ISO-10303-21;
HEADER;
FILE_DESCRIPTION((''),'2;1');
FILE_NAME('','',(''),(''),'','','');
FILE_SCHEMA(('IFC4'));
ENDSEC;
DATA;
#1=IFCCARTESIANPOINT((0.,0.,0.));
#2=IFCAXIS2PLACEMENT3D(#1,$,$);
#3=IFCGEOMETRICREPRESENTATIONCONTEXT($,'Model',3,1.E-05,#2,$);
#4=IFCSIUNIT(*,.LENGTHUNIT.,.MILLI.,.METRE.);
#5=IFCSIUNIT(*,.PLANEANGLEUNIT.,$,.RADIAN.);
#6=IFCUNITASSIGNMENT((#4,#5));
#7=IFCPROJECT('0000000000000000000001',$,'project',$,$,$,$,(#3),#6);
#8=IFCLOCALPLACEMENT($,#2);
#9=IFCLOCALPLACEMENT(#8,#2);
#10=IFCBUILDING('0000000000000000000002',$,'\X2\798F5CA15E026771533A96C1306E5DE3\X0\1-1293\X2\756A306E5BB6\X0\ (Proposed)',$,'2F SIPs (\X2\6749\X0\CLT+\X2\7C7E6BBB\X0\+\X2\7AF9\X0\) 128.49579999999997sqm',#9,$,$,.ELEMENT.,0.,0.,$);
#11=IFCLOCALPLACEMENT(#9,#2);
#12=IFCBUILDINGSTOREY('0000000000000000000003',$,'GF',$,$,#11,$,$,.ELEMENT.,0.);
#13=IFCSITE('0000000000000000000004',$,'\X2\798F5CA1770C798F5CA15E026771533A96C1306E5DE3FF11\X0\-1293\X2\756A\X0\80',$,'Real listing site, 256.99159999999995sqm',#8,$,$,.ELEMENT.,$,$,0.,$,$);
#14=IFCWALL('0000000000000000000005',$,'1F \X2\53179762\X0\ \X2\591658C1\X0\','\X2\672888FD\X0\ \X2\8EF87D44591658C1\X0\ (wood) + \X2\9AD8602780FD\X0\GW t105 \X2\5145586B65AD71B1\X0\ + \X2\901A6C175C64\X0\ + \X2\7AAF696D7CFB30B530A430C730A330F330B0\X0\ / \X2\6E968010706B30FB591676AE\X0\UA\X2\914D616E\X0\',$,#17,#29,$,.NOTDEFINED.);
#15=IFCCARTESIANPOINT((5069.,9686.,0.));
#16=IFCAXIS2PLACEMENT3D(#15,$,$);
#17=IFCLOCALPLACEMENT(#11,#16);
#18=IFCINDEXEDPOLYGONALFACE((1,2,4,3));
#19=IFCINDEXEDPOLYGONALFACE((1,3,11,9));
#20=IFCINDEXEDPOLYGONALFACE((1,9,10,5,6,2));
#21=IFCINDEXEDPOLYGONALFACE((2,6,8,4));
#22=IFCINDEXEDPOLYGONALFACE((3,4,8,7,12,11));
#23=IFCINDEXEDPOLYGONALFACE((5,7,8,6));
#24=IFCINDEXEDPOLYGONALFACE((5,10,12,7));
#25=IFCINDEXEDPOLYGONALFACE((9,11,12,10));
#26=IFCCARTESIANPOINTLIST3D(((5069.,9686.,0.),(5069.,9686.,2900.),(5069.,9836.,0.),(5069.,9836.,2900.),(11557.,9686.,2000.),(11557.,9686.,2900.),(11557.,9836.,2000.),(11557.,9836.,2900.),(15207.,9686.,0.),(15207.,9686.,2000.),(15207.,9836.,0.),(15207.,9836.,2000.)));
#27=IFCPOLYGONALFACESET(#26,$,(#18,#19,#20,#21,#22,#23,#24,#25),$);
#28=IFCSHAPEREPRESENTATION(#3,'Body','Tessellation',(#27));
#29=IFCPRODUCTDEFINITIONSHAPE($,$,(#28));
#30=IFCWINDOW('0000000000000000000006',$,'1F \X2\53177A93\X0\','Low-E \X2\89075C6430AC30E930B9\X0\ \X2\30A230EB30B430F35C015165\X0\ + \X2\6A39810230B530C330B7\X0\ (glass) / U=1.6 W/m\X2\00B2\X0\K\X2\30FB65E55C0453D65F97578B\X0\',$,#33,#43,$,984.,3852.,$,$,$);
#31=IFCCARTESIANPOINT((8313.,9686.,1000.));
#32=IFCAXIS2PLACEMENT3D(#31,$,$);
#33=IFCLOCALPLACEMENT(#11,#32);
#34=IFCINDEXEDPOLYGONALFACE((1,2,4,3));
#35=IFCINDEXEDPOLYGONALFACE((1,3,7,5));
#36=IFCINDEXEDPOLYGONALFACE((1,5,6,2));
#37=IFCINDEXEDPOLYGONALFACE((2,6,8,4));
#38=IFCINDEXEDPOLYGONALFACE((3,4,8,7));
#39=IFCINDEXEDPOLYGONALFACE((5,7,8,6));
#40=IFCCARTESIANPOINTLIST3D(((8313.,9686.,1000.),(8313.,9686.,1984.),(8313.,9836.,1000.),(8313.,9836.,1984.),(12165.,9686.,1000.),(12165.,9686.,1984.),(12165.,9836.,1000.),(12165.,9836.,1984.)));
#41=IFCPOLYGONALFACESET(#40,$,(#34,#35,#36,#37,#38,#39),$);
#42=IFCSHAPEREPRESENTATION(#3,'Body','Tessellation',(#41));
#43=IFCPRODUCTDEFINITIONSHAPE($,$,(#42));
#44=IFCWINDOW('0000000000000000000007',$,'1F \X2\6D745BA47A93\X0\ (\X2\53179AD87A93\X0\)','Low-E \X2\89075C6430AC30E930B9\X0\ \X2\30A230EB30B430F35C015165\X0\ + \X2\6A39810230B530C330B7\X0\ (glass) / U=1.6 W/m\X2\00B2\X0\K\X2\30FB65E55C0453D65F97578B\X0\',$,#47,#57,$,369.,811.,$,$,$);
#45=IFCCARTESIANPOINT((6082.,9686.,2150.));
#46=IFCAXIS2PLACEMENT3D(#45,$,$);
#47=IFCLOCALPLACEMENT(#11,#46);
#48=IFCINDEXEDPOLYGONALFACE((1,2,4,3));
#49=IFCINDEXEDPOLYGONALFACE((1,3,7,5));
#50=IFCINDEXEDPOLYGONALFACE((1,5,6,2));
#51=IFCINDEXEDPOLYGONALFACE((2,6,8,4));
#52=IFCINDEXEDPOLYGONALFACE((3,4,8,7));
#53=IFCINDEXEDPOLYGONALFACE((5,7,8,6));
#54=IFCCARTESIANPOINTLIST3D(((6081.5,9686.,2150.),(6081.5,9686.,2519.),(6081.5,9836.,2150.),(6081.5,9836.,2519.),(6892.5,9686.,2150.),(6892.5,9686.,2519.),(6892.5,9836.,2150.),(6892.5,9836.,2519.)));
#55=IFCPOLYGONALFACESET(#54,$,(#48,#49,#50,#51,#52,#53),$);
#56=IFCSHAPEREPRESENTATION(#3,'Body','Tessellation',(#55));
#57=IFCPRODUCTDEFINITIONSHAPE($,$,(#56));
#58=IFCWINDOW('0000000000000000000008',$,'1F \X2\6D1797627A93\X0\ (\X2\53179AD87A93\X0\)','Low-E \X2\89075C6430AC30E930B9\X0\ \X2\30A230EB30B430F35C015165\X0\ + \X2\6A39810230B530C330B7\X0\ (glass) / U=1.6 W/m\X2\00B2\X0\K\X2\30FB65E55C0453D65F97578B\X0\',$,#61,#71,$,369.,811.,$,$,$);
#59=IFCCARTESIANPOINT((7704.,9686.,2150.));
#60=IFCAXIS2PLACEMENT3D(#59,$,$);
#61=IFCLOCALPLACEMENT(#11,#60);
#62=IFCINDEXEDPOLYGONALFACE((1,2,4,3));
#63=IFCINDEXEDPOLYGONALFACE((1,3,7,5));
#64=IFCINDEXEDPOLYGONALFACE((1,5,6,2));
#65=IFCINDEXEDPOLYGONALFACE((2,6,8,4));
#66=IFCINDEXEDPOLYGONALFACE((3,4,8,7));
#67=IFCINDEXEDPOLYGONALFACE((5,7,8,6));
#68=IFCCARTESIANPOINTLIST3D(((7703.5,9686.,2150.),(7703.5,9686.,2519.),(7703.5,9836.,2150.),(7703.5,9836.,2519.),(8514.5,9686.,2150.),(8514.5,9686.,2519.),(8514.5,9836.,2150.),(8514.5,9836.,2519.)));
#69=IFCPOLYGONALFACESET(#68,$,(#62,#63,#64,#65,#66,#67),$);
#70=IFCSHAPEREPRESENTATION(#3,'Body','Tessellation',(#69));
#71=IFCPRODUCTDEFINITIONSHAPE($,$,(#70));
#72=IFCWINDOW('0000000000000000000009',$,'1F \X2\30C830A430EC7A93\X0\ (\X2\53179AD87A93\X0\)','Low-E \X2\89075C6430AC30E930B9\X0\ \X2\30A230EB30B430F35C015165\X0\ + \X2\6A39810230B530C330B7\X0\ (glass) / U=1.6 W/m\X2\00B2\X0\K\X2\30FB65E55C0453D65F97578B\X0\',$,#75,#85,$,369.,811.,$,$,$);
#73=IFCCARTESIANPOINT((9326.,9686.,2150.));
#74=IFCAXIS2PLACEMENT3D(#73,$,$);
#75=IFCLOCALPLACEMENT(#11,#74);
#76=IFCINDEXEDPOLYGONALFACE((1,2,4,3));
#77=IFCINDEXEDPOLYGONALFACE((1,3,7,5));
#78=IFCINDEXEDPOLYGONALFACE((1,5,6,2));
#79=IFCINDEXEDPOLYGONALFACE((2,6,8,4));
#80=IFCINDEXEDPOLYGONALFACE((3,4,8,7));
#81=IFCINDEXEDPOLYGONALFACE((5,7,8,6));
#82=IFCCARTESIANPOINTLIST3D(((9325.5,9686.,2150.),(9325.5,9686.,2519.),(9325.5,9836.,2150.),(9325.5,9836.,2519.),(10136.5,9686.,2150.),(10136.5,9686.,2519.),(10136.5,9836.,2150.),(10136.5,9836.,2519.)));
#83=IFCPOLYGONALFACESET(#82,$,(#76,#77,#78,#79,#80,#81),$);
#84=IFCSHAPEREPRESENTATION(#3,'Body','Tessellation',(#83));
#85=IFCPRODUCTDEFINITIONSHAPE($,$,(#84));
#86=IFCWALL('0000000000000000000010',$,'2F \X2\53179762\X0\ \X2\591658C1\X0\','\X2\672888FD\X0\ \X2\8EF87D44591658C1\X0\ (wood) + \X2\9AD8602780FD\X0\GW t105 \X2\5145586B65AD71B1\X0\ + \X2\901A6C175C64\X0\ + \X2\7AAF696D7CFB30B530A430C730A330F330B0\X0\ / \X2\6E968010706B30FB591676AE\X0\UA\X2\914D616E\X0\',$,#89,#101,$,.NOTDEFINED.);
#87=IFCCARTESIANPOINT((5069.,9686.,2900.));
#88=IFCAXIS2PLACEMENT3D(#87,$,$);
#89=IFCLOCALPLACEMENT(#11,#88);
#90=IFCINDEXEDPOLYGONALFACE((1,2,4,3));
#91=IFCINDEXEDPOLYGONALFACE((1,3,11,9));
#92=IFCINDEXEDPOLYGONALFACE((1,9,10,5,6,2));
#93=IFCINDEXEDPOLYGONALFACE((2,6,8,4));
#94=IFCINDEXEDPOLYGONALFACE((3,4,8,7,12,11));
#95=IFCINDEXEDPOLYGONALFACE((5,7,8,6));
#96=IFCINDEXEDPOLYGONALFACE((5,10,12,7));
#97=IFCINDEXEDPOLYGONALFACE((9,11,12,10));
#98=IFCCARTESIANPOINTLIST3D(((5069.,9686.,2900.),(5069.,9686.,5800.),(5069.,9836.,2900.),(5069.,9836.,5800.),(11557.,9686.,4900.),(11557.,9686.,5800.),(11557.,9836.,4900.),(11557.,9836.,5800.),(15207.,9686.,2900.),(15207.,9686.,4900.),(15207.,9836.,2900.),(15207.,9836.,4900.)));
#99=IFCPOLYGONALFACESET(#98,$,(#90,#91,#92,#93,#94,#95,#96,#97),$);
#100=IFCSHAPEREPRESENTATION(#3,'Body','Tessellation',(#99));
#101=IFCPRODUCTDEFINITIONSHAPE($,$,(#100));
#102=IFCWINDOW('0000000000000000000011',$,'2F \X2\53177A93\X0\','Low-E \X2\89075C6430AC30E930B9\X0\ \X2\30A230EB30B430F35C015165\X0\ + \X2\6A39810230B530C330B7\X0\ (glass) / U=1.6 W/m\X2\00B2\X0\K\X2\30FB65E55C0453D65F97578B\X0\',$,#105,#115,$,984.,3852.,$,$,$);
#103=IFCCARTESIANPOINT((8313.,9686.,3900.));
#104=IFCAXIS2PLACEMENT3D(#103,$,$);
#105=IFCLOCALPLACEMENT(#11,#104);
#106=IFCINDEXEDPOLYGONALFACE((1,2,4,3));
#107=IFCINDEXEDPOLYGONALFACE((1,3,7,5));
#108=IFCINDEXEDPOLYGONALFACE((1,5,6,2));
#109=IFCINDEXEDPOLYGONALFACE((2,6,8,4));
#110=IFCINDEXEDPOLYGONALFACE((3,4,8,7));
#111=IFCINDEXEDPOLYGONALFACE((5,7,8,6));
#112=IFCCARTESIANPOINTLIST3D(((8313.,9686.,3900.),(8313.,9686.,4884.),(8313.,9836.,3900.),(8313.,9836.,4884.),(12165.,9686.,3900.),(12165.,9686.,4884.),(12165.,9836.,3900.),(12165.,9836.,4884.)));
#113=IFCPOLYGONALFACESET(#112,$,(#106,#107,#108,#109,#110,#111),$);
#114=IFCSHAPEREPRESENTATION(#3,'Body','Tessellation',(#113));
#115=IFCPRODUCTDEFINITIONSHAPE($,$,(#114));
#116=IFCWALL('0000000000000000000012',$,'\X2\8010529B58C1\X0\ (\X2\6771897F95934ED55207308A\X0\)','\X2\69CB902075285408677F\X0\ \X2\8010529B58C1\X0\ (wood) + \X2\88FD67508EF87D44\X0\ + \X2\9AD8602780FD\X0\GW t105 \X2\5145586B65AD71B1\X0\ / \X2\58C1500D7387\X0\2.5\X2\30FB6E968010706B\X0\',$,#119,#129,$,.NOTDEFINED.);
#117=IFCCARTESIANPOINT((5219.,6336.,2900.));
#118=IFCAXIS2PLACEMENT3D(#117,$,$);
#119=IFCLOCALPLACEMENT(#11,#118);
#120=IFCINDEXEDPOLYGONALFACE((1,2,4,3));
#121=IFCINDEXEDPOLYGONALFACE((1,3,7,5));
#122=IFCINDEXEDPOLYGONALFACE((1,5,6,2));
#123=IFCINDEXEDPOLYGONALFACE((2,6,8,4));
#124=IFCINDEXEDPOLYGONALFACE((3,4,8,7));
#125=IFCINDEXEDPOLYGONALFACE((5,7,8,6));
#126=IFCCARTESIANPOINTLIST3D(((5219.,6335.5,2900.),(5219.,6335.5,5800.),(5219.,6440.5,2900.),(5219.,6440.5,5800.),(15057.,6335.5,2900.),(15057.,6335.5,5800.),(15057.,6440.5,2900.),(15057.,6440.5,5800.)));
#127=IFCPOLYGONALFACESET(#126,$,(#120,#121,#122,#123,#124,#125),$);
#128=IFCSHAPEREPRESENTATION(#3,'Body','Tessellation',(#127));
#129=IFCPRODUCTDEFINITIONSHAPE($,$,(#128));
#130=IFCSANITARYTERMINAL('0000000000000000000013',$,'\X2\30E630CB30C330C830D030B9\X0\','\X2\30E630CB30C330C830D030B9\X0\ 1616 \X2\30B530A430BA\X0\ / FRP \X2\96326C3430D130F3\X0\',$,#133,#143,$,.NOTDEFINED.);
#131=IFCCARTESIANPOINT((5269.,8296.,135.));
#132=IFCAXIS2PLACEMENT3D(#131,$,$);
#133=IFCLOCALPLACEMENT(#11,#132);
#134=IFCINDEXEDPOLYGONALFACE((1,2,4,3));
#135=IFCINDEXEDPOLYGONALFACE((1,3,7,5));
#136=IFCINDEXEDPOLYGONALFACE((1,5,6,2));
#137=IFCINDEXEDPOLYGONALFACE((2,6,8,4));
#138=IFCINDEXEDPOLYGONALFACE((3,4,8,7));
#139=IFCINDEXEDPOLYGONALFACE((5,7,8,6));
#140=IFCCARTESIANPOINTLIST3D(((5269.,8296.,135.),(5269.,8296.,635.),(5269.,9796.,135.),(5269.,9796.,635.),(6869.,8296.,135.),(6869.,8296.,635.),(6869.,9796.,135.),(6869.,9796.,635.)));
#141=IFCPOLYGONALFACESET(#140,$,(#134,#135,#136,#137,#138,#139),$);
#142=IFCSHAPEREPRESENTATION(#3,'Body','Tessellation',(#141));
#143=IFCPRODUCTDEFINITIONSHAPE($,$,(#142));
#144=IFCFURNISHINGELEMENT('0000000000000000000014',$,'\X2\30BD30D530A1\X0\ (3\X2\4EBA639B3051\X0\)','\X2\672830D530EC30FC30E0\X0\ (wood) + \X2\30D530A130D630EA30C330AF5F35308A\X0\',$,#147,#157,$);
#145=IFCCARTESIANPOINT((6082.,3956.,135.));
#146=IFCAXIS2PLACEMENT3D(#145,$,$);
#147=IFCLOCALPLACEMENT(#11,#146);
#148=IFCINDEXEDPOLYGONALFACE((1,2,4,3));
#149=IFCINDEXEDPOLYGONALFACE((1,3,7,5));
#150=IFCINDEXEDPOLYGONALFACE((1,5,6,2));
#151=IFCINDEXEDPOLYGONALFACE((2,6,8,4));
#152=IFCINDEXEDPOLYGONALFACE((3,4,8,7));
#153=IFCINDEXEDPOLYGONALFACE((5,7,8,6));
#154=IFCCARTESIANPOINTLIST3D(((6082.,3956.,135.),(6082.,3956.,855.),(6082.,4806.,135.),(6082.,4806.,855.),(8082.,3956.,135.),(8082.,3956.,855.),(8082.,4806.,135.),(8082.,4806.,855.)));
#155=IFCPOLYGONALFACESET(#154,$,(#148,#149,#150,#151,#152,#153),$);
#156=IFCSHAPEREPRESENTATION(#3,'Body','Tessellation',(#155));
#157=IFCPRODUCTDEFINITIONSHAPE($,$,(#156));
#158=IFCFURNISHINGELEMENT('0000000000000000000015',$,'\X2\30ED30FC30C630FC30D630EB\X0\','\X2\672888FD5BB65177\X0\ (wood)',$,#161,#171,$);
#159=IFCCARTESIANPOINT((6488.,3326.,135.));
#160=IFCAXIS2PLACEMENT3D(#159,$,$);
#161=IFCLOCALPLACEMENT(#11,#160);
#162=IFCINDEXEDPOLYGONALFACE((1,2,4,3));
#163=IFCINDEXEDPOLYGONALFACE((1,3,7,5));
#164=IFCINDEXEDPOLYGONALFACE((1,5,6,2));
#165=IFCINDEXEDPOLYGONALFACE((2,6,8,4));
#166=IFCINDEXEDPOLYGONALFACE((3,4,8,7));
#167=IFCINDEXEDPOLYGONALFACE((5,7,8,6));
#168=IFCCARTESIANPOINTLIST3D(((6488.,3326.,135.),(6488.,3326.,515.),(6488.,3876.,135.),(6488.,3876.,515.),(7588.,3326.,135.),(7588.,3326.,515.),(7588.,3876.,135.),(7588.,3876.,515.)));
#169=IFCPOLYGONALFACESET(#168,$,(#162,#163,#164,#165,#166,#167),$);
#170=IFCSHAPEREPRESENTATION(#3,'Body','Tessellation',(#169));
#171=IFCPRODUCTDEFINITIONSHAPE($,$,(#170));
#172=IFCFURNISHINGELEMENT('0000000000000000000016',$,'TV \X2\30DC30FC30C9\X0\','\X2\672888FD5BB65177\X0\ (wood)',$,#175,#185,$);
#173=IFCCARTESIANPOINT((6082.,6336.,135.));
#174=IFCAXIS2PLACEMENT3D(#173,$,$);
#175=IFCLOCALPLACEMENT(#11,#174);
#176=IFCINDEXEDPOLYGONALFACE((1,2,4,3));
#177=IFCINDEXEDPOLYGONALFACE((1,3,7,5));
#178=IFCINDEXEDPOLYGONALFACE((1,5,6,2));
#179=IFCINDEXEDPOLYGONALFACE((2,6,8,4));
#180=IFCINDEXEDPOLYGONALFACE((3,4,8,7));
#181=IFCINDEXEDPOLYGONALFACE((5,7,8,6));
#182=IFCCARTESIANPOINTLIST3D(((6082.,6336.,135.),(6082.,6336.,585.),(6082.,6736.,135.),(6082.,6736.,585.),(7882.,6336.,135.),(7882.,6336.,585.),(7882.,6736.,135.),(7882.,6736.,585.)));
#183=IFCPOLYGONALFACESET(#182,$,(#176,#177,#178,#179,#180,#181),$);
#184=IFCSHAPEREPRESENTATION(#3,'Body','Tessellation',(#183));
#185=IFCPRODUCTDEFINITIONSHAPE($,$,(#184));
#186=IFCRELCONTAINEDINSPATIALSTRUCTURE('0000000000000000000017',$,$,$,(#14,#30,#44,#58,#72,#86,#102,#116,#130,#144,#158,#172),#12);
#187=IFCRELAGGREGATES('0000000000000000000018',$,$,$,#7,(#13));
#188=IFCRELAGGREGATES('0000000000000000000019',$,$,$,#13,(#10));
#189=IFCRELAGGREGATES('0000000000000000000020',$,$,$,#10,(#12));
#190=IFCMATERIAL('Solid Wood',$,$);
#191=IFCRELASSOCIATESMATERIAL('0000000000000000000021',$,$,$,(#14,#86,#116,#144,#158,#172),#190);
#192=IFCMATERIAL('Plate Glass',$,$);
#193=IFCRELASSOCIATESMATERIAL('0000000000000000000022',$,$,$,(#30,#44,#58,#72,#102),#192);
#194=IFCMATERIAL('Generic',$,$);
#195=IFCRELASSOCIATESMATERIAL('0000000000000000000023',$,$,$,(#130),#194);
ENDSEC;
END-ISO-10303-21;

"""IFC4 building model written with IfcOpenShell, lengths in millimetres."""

from ifc_helpers import new_model, si_unit, frame, frame_2d, origin, place, context, project, spatial, rectangle, extrude, material, element, fill, save


model = new_model("IFC4")

# Units and contexts
model_context = context("Model", 3, precision=1e-05, world=origin())
ifc_project = project(units=[si_unit("LENGTHUNIT", "METRE", prefix="MILLI"), si_unit("PLANEANGLEUNIT", "RADIAN")], contexts=[model_context])

# Site, building, storey
site_placement = place(None, origin())
site = spatial("IfcSite", under=ifc_project, at=site_placement, Name="福岡県福岡市東区雁の巣１-1293番80", ObjectType="Real listing site, 256.99159999999995sqm", CompositionType="ELEMENT", RefElevation=0.0)
building_placement = place(site_placement, origin())
building = spatial("IfcBuilding", under=site, at=building_placement, Name="福岡市東区雁の巣1-1293番の家 (Proposed)", ObjectType="2F SIPs (杉CLT+籾殻+竹) 128.49579999999997sqm", CompositionType="ELEMENT", ElevationOfRefHeight=0.0, ElevationOfTerrain=0.0)
storey_placement = place(building_placement, origin())
storey = spatial("IfcBuildingStorey", under=building, at=storey_placement, Name="GF", CompositionType="ELEMENT", Elevation=0.0)

# Wall, openings, windows
ifc_material_1 = material(Name="Solid Wood")
wall_1_placement = place(storey_placement, frame((5069.0, 9686.0, 0.0)))
wall_1 = element("IfcWall", 1, at=wall_1_placement, inside=storey, material=ifc_material_1, Name="1F 北面 外壁", Description="木製 軸組外壁 (wood) + 高性能GW t105 充填断熱 + 通気層 + 窯業系サイディング / 準耐火・外皮UA配慮", PredefinedType="NOTDEFINED", context=model_context, shape_type="SweptSolid", body=[
    extrude(rectangle(XDim=10138.0, YDim=150.0, at=frame_2d((5069.0, 75.0))), frame((5069.0, 9686.0, 0.0)), (0.0, 0.0, 1.0), 2900.0),
])
opening_1_placement = place(storey_placement, frame((8313.0, 9686.0, 1000.0)))
opening_1 = element("IfcOpeningElement", 2, at=opening_1_placement, cuts=wall_1, PredefinedType="NOTDEFINED", context=model_context, shape_type="SweptSolid", body=[
    extrude(rectangle(XDim=3852.0, YDim=150.0, at=frame_2d((1926.0, 75.0))), frame((8313.0, 9686.0, 1000.0)), (0.0, 0.0, 1.0), 984.0),
])
opening_2_placement = place(storey_placement, frame((6082.0, 9686.0, 2150.0)))
opening_2 = element("IfcOpeningElement", 3, at=opening_2_placement, cuts=wall_1, PredefinedType="NOTDEFINED", context=model_context, shape_type="SweptSolid", body=[
    extrude(rectangle(XDim=811.0, YDim=150.0, at=frame_2d((405.0, 75.0))), frame((6082.0, 9686.0, 2150.0)), (0.0, 0.0, 1.0), 369.0),
])
opening_3_placement = place(storey_placement, frame((7704.0, 9686.0, 2150.0)))
opening_3 = element("IfcOpeningElement", 4, at=opening_3_placement, cuts=wall_1, PredefinedType="NOTDEFINED", context=model_context, shape_type="SweptSolid", body=[
    extrude(rectangle(XDim=811.0, YDim=150.0, at=frame_2d((405.0, 75.0))), frame((7704.0, 9686.0, 2150.0)), (0.0, 0.0, 1.0), 369.0),
])
opening_4_placement = place(storey_placement, frame((9326.0, 9686.0, 2150.0)))
opening_4 = element("IfcOpeningElement", 5, at=opening_4_placement, cuts=wall_1, PredefinedType="NOTDEFINED", context=model_context, shape_type="SweptSolid", body=[
    extrude(rectangle(XDim=811.0, YDim=150.0, at=frame_2d((405.0, 75.0))), frame((9326.0, 9686.0, 2150.0)), (0.0, 0.0, 1.0), 369.0),
])
ifc_material_2 = material(Name="Plate Glass")
window_1_placement = place(storey_placement, frame((8313.0, 9686.0, 1000.0)))
window_1 = element("IfcWindow", 6, at=window_1_placement, inside=storey, material=ifc_material_2, Name="1F 北窓", Description="Low-E 複層ガラス アルゴン封入 + 樹脂サッシ (glass) / U=1.6 W/m²K・日射取得型", OverallHeight=984.0, OverallWidth=3852.0, context=model_context, shape_type="SweptSolid", body=[
    extrude(rectangle(XDim=3852.0, YDim=150.0, at=frame_2d((1926.0, 75.0))), frame((8313.0, 9686.0, 1000.0)), (0.0, 0.0, 1.0), 984.0),
])
fill(opening_1, window_1)
window_2_placement = place(storey_placement, frame((6082.0, 9686.0, 2150.0)))
window_2 = element("IfcWindow", 7, at=window_2_placement, inside=storey, material=ifc_material_2, Name="1F 浴室窓 (北高窓)", Description="Low-E 複層ガラス アルゴン封入 + 樹脂サッシ (glass) / U=1.6 W/m²K・日射取得型", OverallHeight=369.0, OverallWidth=811.0, context=model_context, shape_type="SweptSolid", body=[
    extrude(rectangle(XDim=811.0, YDim=150.0, at=frame_2d((405.0, 75.0))), frame((6082.0, 9686.0, 2150.0)), (0.0, 0.0, 1.0), 369.0),
])
fill(opening_2, window_2)
window_3_placement = place(storey_placement, frame((7704.0, 9686.0, 2150.0)))
window_3 = element("IfcWindow", 8, at=window_3_placement, inside=storey, material=ifc_material_2, Name="1F 洗面窓 (北高窓)", Description="Low-E 複層ガラス アルゴン封入 + 樹脂サッシ (glass) / U=1.6 W/m²K・日射取得型", OverallHeight=369.0, OverallWidth=811.0, context=model_context, shape_type="SweptSolid", body=[
    extrude(rectangle(XDim=811.0, YDim=150.0, at=frame_2d((405.0, 75.0))), frame((7704.0, 9686.0, 2150.0)), (0.0, 0.0, 1.0), 369.0),
])
fill(opening_3, window_3)
window_4_placement = place(storey_placement, frame((9326.0, 9686.0, 2150.0)))
window_4 = element("IfcWindow", 9, at=window_4_placement, inside=storey, material=ifc_material_2, Name="1F トイレ窓 (北高窓)", Description="Low-E 複層ガラス アルゴン封入 + 樹脂サッシ (glass) / U=1.6 W/m²K・日射取得型", OverallHeight=369.0, OverallWidth=811.0, context=model_context, shape_type="SweptSolid", body=[
    extrude(rectangle(XDim=811.0, YDim=150.0, at=frame_2d((405.0, 75.0))), frame((9326.0, 9686.0, 2150.0)), (0.0, 0.0, 1.0), 369.0),
])
fill(opening_4, window_4)

# Wall, opening, window
wall_2_placement = place(storey_placement, frame((5069.0, 9686.0, 2900.0)))
wall_2 = element("IfcWall", 10, at=wall_2_placement, inside=storey, material=ifc_material_1, Name="2F 北面 外壁", Description="木製 軸組外壁 (wood) + 高性能GW t105 充填断熱 + 通気層 + 窯業系サイディング / 準耐火・外皮UA配慮", PredefinedType="NOTDEFINED", context=model_context, shape_type="SweptSolid", body=[
    extrude(rectangle(XDim=10138.0, YDim=150.0, at=frame_2d((5069.0, 75.0))), frame((5069.0, 9686.0, 2900.0)), (0.0, 0.0, 1.0), 2900.0),
])
opening_5_placement = place(storey_placement, frame((8313.0, 9686.0, 3900.0)))
opening_5 = element("IfcOpeningElement", 11, at=opening_5_placement, cuts=wall_2, PredefinedType="NOTDEFINED", context=model_context, shape_type="SweptSolid", body=[
    extrude(rectangle(XDim=3852.0, YDim=150.0, at=frame_2d((1926.0, 75.0))), frame((8313.0, 9686.0, 3900.0)), (0.0, 0.0, 1.0), 984.0),
])
window_5_placement = place(storey_placement, frame((8313.0, 9686.0, 3900.0)))
window_5 = element("IfcWindow", 12, at=window_5_placement, inside=storey, material=ifc_material_2, Name="2F 北窓", Description="Low-E 複層ガラス アルゴン封入 + 樹脂サッシ (glass) / U=1.6 W/m²K・日射取得型", OverallHeight=984.0, OverallWidth=3852.0, context=model_context, shape_type="SweptSolid", body=[
    extrude(rectangle(XDim=3852.0, YDim=150.0, at=frame_2d((1926.0, 75.0))), frame((8313.0, 9686.0, 3900.0)), (0.0, 0.0, 1.0), 984.0),
])
fill(opening_5, window_5)

# Wall
wall_3_placement = place(storey_placement, frame((5219.0, 6336.0, 2900.0)))
element("IfcWall", 13, at=wall_3_placement, inside=storey, material=ifc_material_1, Name="耐力壁 (東西間仕切り)", Description="構造用合板 耐力壁 (wood) + 製材軸組 + 高性能GW t105 充填断熱 / 壁倍率2.5・準耐火", PredefinedType="NOTDEFINED", context=model_context, shape_type="SweptSolid", body=[
    extrude(rectangle(XDim=9838.0, YDim=105.0, at=frame_2d((4919.0, 52.0))), frame((5219.0, 6336.0, 2900.0)), (0.0, 0.0, 1.0), 2900.0),
])

# Sanitary terminal
ifc_material_3 = material(Name="Generic")
sanitary_terminal_placement = place(storey_placement, frame((5269.0, 8296.0, 135.0)))
element("IfcSanitaryTerminal", 14, at=sanitary_terminal_placement, inside=storey, material=ifc_material_3, Name="ユニットバス", Description="ユニットバス 1616 サイズ / FRP 防水パン", PredefinedType="NOTDEFINED", context=model_context, shape_type="SweptSolid", body=[
    extrude(rectangle(XDim=1600.0, YDim=1500.0, at=frame_2d((800.0, 750.0))), frame((5269.0, 8296.0, 135.0)), (0.0, 0.0, 1.0), 500.0),
])

# Furnishing elements
furnishing_1_placement = place(storey_placement, frame((6082.0, 3956.0, 135.0)))
element("IfcFurnishingElement", 15, at=furnishing_1_placement, inside=storey, material=ifc_material_1, Name="ソファ (3人掛け)", Description="木フレーム (wood) + ファブリック張り", context=model_context, shape_type="SweptSolid", body=[
    extrude(rectangle(XDim=2000.0, YDim=850.0, at=frame_2d((1000.0, 425.0))), frame((6082.0, 3956.0, 135.0)), (0.0, 0.0, 1.0), 720.0),
])
furnishing_2_placement = place(storey_placement, frame((6488.0, 3326.0, 135.0)))
element("IfcFurnishingElement", 16, at=furnishing_2_placement, inside=storey, material=ifc_material_1, Name="ローテーブル", Description="木製家具 (wood)", context=model_context, shape_type="SweptSolid", body=[
    extrude(rectangle(XDim=1100.0, YDim=550.0, at=frame_2d((550.0, 275.0))), frame((6488.0, 3326.0, 135.0)), (0.0, 0.0, 1.0), 380.0),
])
furnishing_3_placement = place(storey_placement, frame((6082.0, 6336.0, 135.0)))
element("IfcFurnishingElement", 17, at=furnishing_3_placement, inside=storey, material=ifc_material_1, Name="TV ボード", Description="木製家具 (wood)", context=model_context, shape_type="SweptSolid", body=[
    extrude(rectangle(XDim=1800.0, YDim=400.0, at=frame_2d((900.0, 200.0))), frame((6082.0, 6336.0, 135.0)), (0.0, 0.0, 1.0), 450.0),
])

save(model, "model.ifc")
